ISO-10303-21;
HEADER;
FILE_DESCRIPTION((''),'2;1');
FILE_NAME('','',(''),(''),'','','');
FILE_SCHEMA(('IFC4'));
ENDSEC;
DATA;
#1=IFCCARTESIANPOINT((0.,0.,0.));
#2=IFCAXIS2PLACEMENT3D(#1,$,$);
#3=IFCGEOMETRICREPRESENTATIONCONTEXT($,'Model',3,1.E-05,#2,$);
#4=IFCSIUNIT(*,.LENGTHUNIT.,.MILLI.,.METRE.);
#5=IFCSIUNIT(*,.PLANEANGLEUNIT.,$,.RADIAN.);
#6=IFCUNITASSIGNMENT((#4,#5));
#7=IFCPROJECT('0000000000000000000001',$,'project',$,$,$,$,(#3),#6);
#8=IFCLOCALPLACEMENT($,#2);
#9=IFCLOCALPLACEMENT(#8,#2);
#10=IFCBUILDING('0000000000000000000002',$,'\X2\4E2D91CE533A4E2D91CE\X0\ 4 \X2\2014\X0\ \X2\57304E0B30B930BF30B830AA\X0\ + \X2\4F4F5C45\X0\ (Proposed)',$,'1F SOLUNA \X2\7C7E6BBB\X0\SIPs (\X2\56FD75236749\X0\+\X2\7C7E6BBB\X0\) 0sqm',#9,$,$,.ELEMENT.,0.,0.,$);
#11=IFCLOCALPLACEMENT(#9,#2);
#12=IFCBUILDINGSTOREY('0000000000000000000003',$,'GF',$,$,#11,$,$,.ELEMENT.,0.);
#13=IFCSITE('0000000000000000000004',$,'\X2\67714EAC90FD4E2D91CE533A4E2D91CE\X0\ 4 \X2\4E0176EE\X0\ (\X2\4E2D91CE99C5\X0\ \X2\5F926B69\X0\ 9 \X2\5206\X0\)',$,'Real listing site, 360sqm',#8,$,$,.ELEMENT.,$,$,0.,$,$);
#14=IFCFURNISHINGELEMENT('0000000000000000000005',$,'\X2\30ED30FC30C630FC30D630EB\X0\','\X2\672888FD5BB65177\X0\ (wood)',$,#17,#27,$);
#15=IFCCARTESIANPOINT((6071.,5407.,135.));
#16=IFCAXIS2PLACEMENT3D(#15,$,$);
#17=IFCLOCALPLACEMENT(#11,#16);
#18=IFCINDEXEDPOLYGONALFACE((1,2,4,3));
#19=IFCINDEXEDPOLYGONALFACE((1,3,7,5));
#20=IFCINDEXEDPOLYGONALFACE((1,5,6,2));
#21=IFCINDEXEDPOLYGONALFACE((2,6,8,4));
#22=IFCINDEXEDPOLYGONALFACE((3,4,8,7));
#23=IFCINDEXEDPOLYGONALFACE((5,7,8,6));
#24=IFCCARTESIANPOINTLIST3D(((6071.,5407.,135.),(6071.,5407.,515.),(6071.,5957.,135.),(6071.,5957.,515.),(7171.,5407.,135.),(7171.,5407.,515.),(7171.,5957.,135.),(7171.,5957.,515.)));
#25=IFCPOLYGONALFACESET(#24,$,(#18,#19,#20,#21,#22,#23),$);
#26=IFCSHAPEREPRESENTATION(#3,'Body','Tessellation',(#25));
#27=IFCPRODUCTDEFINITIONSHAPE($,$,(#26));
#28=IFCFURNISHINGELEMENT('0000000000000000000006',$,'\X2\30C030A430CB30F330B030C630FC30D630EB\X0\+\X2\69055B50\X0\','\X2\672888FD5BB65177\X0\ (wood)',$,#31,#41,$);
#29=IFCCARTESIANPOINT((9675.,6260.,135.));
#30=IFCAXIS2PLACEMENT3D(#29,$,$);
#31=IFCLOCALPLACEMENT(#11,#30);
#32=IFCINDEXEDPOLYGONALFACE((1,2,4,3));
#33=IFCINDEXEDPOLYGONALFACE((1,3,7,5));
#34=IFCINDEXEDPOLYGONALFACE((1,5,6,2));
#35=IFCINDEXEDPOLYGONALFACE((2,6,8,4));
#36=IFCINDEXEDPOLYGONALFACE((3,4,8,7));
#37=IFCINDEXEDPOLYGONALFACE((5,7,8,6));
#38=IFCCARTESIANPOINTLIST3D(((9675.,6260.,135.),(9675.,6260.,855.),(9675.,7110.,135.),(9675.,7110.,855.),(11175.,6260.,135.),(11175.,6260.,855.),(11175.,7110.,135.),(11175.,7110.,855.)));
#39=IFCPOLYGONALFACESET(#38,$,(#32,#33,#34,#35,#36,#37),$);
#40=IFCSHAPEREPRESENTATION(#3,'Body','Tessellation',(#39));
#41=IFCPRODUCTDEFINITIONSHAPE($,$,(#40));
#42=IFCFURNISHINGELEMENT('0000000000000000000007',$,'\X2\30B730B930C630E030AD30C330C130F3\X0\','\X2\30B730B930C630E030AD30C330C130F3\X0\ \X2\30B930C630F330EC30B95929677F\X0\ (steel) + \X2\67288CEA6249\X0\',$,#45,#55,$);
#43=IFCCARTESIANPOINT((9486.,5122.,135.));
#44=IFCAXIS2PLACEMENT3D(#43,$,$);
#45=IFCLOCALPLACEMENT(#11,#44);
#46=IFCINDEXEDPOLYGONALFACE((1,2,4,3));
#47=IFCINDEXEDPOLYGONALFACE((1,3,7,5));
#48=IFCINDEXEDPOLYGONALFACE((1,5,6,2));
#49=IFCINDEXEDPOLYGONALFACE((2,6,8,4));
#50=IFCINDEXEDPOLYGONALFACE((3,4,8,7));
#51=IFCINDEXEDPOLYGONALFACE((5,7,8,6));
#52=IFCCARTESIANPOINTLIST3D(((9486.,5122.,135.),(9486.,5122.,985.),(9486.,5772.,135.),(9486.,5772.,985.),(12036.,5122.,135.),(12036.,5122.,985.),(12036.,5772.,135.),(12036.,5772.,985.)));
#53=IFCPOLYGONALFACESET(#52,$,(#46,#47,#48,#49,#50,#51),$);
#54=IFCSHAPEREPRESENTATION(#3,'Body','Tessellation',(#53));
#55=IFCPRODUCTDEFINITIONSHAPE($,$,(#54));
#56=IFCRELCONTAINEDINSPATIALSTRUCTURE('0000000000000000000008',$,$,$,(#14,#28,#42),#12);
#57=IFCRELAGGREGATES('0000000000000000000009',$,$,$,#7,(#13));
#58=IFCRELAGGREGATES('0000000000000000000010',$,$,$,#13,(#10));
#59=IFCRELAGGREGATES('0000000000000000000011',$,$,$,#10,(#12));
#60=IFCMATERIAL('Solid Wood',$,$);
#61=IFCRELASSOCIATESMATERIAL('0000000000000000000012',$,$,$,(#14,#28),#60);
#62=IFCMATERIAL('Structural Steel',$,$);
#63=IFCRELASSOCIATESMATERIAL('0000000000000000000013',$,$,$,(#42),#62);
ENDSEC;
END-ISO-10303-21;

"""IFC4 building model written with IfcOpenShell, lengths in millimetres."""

from ifc_helpers import new_model, si_unit, frame, frame_2d, origin, place, context, project, spatial, rectangle, extrude, material, element, save


model = new_model("IFC4")

# Units and contexts
model_context = context("Model", 3, precision=1e-05, world=origin())
ifc_project = project(units=[si_unit("LENGTHUNIT", "METRE", prefix="MILLI"), si_unit("PLANEANGLEUNIT", "RADIAN")], contexts=[model_context])

# Site, building, storey
site_placement = place(None, origin())
site = spatial("IfcSite", under=ifc_project, at=site_placement, Name="東京都中野区中野 4 丁目 (中野駅 徒歩 9 分)", ObjectType="Real listing site, 360sqm", CompositionType="ELEMENT", RefElevation=0.0)
building_placement = place(site_placement, origin())
building = spatial("IfcBuilding", under=site, at=building_placement, Name="中野区中野 4 — 地下スタジオ + 住居 (Proposed)", ObjectType="1F SOLUNA 籾殻SIPs (国産杉+籾殻) 0sqm", CompositionType="ELEMENT", ElevationOfRefHeight=0.0, ElevationOfTerrain=0.0)
storey_placement = place(building_placement, origin())
storey = spatial("IfcBuildingStorey", under=building, at=storey_placement, Name="GF", CompositionType="ELEMENT", Elevation=0.0)

# Shared definitions
ifc_material_1 = material(Name="Solid Wood")

# Shared definitions
ifc_material_2 = material(Name="Structural Steel")

# Furnishing elements
furnishing_1_placement = place(storey_placement, frame((6071.0, 5407.0, 135.0)))
element("IfcFurnishingElement", 1, at=furnishing_1_placement, inside=storey, material=ifc_material_1, Name="ローテーブル", Description="木製家具 (wood)", context=model_context, shape_type="SweptSolid", body=[
    extrude(rectangle(XDim=1100.0, YDim=550.0, at=frame_2d((550.0, 275.0))), frame((6071.0, 5407.0, 135.0)), (0.0, 0.0, 1.0), 380.0),
])
furnishing_2_placement = place(storey_placement, frame((9675.0, 6260.0, 135.0)))
element("IfcFurnishingElement", 2, at=furnishing_2_placement, inside=storey, material=ifc_material_1, Name="ダイニングテーブル+椅子", Description="木製家具 (wood)", context=model_context, shape_type="SweptSolid", body=[
    extrude(rectangle(XDim=1500.0, YDim=850.0, at=frame_2d((750.0, 425.0))), frame((9675.0, 6260.0, 135.0)), (0.0, 0.0, 1.0), 720.0),
])
furnishing_3_placement = place(storey_placement, frame((9486.0, 5122.0, 135.0)))
element("IfcFurnishingElement", 3, at=furnishing_3_placement, inside=storey, material=ifc_material_2, Name="システムキッチン", Description="システムキッチン ステンレス天板 (steel) + 木質扉", context=model_context, shape_type="SweptSolid", body=[
    extrude(rectangle(XDim=2550.0, YDim=650.0, at=frame_2d((1275.0, 325.0))), frame((9486.0, 5122.0, 135.0)), (0.0, 0.0, 1.0), 850.0),
])

save(model, "model.ifc")
